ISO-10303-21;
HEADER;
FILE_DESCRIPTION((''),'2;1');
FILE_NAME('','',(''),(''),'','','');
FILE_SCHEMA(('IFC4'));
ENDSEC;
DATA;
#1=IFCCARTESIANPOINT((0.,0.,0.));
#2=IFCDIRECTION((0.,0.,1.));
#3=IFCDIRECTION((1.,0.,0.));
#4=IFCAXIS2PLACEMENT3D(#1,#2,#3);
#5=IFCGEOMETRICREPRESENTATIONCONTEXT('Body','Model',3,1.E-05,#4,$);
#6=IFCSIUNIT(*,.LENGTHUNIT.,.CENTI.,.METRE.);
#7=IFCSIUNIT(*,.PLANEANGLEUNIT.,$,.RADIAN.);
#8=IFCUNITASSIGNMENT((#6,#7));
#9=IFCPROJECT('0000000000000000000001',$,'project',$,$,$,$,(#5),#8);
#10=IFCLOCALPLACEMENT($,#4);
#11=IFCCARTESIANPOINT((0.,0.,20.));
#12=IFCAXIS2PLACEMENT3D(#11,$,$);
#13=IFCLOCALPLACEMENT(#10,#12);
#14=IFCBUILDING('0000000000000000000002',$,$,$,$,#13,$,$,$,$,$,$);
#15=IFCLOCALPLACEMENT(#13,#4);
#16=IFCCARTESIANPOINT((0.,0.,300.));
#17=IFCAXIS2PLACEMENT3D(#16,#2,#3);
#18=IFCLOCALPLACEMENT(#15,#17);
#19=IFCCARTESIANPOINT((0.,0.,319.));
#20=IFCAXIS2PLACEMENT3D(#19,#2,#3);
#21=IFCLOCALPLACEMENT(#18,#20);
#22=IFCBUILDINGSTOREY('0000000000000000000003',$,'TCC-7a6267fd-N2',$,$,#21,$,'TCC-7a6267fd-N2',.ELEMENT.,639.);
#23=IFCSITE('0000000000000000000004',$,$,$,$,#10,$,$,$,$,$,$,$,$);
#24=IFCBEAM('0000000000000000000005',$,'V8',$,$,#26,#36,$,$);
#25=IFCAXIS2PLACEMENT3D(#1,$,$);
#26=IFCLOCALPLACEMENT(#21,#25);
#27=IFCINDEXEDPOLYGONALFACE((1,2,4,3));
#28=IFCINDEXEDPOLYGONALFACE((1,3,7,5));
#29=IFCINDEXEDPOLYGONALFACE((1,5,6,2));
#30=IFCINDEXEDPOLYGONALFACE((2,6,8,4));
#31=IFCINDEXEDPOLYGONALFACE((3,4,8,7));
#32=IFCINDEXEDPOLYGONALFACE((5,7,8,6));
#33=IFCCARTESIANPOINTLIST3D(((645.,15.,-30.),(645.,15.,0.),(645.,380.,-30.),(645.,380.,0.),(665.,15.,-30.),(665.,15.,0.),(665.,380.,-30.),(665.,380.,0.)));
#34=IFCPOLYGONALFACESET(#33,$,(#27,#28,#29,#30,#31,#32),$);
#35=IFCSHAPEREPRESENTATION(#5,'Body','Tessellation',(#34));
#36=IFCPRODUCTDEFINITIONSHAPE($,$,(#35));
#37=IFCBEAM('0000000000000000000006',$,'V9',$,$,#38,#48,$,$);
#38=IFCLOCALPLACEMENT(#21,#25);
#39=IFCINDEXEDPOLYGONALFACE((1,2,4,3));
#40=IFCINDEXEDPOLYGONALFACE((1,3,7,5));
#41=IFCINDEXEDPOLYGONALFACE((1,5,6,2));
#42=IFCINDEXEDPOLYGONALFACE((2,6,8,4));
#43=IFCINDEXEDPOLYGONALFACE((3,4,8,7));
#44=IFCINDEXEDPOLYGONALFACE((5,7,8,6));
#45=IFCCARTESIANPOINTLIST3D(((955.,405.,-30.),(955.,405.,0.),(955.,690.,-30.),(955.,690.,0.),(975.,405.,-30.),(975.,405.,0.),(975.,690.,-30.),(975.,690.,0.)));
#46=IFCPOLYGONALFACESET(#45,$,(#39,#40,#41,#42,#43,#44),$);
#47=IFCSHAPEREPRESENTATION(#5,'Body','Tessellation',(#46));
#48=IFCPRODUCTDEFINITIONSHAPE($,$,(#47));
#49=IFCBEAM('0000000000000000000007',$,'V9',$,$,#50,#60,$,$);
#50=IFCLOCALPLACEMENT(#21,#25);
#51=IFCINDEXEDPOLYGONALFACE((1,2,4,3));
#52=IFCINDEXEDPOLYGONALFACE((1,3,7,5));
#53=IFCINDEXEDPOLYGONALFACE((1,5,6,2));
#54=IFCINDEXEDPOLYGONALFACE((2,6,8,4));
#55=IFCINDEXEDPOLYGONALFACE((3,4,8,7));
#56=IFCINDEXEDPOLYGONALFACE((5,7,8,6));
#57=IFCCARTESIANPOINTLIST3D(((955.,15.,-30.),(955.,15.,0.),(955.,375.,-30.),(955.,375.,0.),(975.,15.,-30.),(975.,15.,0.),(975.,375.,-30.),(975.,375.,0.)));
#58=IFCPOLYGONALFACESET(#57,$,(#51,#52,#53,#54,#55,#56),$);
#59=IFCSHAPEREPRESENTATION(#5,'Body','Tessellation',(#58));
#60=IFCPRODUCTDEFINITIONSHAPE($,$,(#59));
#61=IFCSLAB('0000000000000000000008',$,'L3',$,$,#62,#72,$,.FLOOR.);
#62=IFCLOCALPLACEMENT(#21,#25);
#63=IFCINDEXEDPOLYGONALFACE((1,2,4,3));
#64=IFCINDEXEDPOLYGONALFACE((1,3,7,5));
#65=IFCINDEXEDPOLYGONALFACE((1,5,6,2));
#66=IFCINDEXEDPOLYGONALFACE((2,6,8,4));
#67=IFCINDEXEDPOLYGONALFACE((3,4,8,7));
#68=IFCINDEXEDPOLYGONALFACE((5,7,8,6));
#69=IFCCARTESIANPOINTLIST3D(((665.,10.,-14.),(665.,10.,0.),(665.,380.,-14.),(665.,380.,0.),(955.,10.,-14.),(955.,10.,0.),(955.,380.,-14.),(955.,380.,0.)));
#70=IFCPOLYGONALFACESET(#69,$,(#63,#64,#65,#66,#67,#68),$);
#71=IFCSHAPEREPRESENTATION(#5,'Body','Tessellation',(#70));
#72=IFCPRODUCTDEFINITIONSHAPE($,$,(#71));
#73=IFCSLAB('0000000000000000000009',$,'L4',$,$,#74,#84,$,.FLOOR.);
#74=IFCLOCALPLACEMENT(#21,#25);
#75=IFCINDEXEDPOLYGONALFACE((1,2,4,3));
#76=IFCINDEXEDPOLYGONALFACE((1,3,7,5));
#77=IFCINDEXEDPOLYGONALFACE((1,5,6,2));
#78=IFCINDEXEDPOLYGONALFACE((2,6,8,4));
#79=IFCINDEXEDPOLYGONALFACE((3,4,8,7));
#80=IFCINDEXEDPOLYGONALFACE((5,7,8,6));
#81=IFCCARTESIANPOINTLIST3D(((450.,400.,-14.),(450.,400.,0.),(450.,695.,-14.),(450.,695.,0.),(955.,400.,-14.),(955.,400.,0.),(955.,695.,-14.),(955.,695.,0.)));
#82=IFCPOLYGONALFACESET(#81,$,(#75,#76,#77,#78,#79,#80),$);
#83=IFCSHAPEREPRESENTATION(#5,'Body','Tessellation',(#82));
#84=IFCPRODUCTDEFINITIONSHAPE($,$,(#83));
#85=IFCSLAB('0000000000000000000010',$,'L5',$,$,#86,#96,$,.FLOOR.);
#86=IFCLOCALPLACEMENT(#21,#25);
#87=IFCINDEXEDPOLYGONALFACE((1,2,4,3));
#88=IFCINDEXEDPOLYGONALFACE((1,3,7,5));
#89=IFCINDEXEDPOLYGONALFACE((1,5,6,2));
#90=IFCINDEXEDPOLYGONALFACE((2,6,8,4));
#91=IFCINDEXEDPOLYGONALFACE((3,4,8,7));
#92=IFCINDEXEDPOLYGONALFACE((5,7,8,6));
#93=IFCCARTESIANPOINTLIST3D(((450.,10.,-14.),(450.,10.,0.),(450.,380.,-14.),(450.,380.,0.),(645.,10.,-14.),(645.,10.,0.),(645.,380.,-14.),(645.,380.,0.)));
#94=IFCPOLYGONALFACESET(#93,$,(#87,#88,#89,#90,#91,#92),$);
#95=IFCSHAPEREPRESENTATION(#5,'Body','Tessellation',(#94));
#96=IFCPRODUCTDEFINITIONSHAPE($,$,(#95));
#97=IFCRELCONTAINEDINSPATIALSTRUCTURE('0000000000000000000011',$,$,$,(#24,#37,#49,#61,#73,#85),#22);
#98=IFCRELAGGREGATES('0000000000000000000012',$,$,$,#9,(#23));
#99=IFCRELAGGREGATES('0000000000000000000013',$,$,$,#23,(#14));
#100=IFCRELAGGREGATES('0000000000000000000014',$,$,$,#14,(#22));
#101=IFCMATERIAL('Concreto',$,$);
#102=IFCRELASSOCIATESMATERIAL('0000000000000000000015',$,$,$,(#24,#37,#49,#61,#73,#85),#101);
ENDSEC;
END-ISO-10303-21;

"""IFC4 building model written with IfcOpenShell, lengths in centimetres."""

from ifc_helpers import new_model, si_unit, frame, origin_with_axes, origin_2d_with_axis, place, context, project, spatial, polyline, rectangle, outline, extrude, material, element, save


model = new_model("IFC4")

# Units and contexts
model_context = context("Model", 3, precision=1e-05, world=origin_with_axes(), identifier="Body")
ifc_project = project(units=[si_unit("LENGTHUNIT", "METRE", prefix="CENTI"), si_unit("PLANEANGLEUNIT", "RADIAN")], contexts=[model_context])

# Site, building, storey
site_placement = place(None, origin_with_axes())
site = spatial("IfcSite", under=ifc_project, at=site_placement)
building_placement = place(site_placement, frame((0.0, 0.0, 20.0)))
building = spatial("IfcBuilding", under=site, at=building_placement)
placement_1 = place(building_placement, origin_with_axes())
placement_2 = place(placement_1, frame((0.0, 0.0, 300.0), z_axis=(0.0, 0.0, 1.0), x_axis=(1.0, 0.0, 0.0)))
storey_placement = place(placement_2, frame((0.0, 0.0, 319.0), z_axis=(0.0, 0.0, 1.0), x_axis=(1.0, 0.0, 0.0)))
storey = spatial("IfcBuildingStorey", under=building, at=storey_placement, Name="TCC-7a6267fd-N2", LongName="TCC-7a6267fd-N2", CompositionType="ELEMENT", Elevation=639.0)

# Shared definitions
ifc_material = material(Name="Concreto")

# Beams
beam_1_placement = place(storey_placement, frame((655.0, 197.5, 0.0), z_axis=(0.0, 0.0, 1.0), x_axis=(1.0, 0.0, 0.0)))
element("IfcBeam", 1, at=beam_1_placement, inside=storey, material=ifc_material, Name="V8", context=model_context, shape_type="SolidModel", body=[
    extrude(rectangle(XDim=20.0, YDim=30.0, at=origin_2d_with_axis()), frame((0.0, -182.5, -15.0), z_axis=(0.0, 1.0, 0.0), x_axis=(1.0, 0.0, 0.0)), (0.0, 0.0, 1.0), 365.0),
])
beam_2_placement = place(storey_placement, frame((965.0, 547.5, 0.0), z_axis=(0.0, 0.0, 1.0), x_axis=(1.0, 0.0, 0.0)))
element("IfcBeam", 2, at=beam_2_placement, inside=storey, material=ifc_material, Name="V9", context=model_context, shape_type="SolidModel", body=[
    extrude(rectangle(XDim=20.0, YDim=30.0, at=origin_2d_with_axis()), frame((0.0, -142.5, -15.0), z_axis=(0.0, 1.0, 0.0), x_axis=(1.0, 0.0, 0.0)), (0.0, 0.0, 1.0), 285.0),
])
beam_3_placement = place(storey_placement, frame((965.0, 195.0, 0.0), z_axis=(0.0, 0.0, 1.0), x_axis=(1.0, 0.0, 0.0)))
element("IfcBeam", 3, at=beam_3_placement, inside=storey, material=ifc_material, Name="V9", context=model_context, shape_type="SolidModel", body=[
    extrude(rectangle(XDim=20.0, YDim=30.0, at=origin_2d_with_axis()), frame((0.0, -180.0, -15.0), z_axis=(0.0, 1.0, 0.0), x_axis=(1.0, 0.0, 0.0)), (0.0, 0.0, 1.0), 360.0),
])

# Slabs
slab_1_placement = place(storey_placement, frame((810.0, 195.0, 0.0), z_axis=(0.0, 0.0, 1.0), x_axis=(1.0, 0.0, 0.0)))
element("IfcSlab", 4, at=slab_1_placement, inside=storey, material=ifc_material, Name="L3", PredefinedType="FLOOR", context=model_context, shape_type="SolidModel", body=[
    extrude(outline(polyline([(145.0, 185.0), (-145.0, 185.0), (-145.0, -185.0), (145.0, -185.0), (145.0, 185.0), (145.0, 185.0)])), frame((0.0, 0.0, -14.0), z_axis=(0.0, 0.0, 1.0), x_axis=(1.0, 0.0, 0.0)), (0.0, 0.0, 1.0), 14.0),
])
slab_2_placement = place(storey_placement, frame((702.5, 547.5, 0.0), z_axis=(0.0, 0.0, 1.0), x_axis=(1.0, 0.0, 0.0)))
element("IfcSlab", 5, at=slab_2_placement, inside=storey, material=ifc_material, Name="L4", PredefinedType="FLOOR", context=model_context, shape_type="SolidModel", body=[
    extrude(outline(polyline([(252.5, 147.5), (-252.5, 147.5), (-252.5, -147.5), (252.5, -147.5), (252.5, 147.5), (252.5, 147.5)])), frame((0.0, 0.0, -14.0), z_axis=(0.0, 0.0, 1.0), x_axis=(1.0, 0.0, 0.0)), (0.0, 0.0, 1.0), 14.0),
])
slab_3_placement = place(storey_placement, frame((547.5, 195.0, 0.0), z_axis=(0.0, 0.0, 1.0), x_axis=(1.0, 0.0, 0.0)))
element("IfcSlab", 6, at=slab_3_placement, inside=storey, material=ifc_material, Name="L5", PredefinedType="FLOOR", context=model_context, shape_type="SolidModel", body=[
    extrude(outline(polyline([(97.5, 185.0), (-97.5, 185.0), (-97.5, -185.0), (97.5, -185.0), (97.5, 185.0), (97.5, 185.0)])), frame((0.0, 0.0, -14.0), z_axis=(0.0, 0.0, 1.0), x_axis=(1.0, 0.0, 0.0)), (0.0, 0.0, 1.0), 14.0),
])

save(model, "model.ifc")
